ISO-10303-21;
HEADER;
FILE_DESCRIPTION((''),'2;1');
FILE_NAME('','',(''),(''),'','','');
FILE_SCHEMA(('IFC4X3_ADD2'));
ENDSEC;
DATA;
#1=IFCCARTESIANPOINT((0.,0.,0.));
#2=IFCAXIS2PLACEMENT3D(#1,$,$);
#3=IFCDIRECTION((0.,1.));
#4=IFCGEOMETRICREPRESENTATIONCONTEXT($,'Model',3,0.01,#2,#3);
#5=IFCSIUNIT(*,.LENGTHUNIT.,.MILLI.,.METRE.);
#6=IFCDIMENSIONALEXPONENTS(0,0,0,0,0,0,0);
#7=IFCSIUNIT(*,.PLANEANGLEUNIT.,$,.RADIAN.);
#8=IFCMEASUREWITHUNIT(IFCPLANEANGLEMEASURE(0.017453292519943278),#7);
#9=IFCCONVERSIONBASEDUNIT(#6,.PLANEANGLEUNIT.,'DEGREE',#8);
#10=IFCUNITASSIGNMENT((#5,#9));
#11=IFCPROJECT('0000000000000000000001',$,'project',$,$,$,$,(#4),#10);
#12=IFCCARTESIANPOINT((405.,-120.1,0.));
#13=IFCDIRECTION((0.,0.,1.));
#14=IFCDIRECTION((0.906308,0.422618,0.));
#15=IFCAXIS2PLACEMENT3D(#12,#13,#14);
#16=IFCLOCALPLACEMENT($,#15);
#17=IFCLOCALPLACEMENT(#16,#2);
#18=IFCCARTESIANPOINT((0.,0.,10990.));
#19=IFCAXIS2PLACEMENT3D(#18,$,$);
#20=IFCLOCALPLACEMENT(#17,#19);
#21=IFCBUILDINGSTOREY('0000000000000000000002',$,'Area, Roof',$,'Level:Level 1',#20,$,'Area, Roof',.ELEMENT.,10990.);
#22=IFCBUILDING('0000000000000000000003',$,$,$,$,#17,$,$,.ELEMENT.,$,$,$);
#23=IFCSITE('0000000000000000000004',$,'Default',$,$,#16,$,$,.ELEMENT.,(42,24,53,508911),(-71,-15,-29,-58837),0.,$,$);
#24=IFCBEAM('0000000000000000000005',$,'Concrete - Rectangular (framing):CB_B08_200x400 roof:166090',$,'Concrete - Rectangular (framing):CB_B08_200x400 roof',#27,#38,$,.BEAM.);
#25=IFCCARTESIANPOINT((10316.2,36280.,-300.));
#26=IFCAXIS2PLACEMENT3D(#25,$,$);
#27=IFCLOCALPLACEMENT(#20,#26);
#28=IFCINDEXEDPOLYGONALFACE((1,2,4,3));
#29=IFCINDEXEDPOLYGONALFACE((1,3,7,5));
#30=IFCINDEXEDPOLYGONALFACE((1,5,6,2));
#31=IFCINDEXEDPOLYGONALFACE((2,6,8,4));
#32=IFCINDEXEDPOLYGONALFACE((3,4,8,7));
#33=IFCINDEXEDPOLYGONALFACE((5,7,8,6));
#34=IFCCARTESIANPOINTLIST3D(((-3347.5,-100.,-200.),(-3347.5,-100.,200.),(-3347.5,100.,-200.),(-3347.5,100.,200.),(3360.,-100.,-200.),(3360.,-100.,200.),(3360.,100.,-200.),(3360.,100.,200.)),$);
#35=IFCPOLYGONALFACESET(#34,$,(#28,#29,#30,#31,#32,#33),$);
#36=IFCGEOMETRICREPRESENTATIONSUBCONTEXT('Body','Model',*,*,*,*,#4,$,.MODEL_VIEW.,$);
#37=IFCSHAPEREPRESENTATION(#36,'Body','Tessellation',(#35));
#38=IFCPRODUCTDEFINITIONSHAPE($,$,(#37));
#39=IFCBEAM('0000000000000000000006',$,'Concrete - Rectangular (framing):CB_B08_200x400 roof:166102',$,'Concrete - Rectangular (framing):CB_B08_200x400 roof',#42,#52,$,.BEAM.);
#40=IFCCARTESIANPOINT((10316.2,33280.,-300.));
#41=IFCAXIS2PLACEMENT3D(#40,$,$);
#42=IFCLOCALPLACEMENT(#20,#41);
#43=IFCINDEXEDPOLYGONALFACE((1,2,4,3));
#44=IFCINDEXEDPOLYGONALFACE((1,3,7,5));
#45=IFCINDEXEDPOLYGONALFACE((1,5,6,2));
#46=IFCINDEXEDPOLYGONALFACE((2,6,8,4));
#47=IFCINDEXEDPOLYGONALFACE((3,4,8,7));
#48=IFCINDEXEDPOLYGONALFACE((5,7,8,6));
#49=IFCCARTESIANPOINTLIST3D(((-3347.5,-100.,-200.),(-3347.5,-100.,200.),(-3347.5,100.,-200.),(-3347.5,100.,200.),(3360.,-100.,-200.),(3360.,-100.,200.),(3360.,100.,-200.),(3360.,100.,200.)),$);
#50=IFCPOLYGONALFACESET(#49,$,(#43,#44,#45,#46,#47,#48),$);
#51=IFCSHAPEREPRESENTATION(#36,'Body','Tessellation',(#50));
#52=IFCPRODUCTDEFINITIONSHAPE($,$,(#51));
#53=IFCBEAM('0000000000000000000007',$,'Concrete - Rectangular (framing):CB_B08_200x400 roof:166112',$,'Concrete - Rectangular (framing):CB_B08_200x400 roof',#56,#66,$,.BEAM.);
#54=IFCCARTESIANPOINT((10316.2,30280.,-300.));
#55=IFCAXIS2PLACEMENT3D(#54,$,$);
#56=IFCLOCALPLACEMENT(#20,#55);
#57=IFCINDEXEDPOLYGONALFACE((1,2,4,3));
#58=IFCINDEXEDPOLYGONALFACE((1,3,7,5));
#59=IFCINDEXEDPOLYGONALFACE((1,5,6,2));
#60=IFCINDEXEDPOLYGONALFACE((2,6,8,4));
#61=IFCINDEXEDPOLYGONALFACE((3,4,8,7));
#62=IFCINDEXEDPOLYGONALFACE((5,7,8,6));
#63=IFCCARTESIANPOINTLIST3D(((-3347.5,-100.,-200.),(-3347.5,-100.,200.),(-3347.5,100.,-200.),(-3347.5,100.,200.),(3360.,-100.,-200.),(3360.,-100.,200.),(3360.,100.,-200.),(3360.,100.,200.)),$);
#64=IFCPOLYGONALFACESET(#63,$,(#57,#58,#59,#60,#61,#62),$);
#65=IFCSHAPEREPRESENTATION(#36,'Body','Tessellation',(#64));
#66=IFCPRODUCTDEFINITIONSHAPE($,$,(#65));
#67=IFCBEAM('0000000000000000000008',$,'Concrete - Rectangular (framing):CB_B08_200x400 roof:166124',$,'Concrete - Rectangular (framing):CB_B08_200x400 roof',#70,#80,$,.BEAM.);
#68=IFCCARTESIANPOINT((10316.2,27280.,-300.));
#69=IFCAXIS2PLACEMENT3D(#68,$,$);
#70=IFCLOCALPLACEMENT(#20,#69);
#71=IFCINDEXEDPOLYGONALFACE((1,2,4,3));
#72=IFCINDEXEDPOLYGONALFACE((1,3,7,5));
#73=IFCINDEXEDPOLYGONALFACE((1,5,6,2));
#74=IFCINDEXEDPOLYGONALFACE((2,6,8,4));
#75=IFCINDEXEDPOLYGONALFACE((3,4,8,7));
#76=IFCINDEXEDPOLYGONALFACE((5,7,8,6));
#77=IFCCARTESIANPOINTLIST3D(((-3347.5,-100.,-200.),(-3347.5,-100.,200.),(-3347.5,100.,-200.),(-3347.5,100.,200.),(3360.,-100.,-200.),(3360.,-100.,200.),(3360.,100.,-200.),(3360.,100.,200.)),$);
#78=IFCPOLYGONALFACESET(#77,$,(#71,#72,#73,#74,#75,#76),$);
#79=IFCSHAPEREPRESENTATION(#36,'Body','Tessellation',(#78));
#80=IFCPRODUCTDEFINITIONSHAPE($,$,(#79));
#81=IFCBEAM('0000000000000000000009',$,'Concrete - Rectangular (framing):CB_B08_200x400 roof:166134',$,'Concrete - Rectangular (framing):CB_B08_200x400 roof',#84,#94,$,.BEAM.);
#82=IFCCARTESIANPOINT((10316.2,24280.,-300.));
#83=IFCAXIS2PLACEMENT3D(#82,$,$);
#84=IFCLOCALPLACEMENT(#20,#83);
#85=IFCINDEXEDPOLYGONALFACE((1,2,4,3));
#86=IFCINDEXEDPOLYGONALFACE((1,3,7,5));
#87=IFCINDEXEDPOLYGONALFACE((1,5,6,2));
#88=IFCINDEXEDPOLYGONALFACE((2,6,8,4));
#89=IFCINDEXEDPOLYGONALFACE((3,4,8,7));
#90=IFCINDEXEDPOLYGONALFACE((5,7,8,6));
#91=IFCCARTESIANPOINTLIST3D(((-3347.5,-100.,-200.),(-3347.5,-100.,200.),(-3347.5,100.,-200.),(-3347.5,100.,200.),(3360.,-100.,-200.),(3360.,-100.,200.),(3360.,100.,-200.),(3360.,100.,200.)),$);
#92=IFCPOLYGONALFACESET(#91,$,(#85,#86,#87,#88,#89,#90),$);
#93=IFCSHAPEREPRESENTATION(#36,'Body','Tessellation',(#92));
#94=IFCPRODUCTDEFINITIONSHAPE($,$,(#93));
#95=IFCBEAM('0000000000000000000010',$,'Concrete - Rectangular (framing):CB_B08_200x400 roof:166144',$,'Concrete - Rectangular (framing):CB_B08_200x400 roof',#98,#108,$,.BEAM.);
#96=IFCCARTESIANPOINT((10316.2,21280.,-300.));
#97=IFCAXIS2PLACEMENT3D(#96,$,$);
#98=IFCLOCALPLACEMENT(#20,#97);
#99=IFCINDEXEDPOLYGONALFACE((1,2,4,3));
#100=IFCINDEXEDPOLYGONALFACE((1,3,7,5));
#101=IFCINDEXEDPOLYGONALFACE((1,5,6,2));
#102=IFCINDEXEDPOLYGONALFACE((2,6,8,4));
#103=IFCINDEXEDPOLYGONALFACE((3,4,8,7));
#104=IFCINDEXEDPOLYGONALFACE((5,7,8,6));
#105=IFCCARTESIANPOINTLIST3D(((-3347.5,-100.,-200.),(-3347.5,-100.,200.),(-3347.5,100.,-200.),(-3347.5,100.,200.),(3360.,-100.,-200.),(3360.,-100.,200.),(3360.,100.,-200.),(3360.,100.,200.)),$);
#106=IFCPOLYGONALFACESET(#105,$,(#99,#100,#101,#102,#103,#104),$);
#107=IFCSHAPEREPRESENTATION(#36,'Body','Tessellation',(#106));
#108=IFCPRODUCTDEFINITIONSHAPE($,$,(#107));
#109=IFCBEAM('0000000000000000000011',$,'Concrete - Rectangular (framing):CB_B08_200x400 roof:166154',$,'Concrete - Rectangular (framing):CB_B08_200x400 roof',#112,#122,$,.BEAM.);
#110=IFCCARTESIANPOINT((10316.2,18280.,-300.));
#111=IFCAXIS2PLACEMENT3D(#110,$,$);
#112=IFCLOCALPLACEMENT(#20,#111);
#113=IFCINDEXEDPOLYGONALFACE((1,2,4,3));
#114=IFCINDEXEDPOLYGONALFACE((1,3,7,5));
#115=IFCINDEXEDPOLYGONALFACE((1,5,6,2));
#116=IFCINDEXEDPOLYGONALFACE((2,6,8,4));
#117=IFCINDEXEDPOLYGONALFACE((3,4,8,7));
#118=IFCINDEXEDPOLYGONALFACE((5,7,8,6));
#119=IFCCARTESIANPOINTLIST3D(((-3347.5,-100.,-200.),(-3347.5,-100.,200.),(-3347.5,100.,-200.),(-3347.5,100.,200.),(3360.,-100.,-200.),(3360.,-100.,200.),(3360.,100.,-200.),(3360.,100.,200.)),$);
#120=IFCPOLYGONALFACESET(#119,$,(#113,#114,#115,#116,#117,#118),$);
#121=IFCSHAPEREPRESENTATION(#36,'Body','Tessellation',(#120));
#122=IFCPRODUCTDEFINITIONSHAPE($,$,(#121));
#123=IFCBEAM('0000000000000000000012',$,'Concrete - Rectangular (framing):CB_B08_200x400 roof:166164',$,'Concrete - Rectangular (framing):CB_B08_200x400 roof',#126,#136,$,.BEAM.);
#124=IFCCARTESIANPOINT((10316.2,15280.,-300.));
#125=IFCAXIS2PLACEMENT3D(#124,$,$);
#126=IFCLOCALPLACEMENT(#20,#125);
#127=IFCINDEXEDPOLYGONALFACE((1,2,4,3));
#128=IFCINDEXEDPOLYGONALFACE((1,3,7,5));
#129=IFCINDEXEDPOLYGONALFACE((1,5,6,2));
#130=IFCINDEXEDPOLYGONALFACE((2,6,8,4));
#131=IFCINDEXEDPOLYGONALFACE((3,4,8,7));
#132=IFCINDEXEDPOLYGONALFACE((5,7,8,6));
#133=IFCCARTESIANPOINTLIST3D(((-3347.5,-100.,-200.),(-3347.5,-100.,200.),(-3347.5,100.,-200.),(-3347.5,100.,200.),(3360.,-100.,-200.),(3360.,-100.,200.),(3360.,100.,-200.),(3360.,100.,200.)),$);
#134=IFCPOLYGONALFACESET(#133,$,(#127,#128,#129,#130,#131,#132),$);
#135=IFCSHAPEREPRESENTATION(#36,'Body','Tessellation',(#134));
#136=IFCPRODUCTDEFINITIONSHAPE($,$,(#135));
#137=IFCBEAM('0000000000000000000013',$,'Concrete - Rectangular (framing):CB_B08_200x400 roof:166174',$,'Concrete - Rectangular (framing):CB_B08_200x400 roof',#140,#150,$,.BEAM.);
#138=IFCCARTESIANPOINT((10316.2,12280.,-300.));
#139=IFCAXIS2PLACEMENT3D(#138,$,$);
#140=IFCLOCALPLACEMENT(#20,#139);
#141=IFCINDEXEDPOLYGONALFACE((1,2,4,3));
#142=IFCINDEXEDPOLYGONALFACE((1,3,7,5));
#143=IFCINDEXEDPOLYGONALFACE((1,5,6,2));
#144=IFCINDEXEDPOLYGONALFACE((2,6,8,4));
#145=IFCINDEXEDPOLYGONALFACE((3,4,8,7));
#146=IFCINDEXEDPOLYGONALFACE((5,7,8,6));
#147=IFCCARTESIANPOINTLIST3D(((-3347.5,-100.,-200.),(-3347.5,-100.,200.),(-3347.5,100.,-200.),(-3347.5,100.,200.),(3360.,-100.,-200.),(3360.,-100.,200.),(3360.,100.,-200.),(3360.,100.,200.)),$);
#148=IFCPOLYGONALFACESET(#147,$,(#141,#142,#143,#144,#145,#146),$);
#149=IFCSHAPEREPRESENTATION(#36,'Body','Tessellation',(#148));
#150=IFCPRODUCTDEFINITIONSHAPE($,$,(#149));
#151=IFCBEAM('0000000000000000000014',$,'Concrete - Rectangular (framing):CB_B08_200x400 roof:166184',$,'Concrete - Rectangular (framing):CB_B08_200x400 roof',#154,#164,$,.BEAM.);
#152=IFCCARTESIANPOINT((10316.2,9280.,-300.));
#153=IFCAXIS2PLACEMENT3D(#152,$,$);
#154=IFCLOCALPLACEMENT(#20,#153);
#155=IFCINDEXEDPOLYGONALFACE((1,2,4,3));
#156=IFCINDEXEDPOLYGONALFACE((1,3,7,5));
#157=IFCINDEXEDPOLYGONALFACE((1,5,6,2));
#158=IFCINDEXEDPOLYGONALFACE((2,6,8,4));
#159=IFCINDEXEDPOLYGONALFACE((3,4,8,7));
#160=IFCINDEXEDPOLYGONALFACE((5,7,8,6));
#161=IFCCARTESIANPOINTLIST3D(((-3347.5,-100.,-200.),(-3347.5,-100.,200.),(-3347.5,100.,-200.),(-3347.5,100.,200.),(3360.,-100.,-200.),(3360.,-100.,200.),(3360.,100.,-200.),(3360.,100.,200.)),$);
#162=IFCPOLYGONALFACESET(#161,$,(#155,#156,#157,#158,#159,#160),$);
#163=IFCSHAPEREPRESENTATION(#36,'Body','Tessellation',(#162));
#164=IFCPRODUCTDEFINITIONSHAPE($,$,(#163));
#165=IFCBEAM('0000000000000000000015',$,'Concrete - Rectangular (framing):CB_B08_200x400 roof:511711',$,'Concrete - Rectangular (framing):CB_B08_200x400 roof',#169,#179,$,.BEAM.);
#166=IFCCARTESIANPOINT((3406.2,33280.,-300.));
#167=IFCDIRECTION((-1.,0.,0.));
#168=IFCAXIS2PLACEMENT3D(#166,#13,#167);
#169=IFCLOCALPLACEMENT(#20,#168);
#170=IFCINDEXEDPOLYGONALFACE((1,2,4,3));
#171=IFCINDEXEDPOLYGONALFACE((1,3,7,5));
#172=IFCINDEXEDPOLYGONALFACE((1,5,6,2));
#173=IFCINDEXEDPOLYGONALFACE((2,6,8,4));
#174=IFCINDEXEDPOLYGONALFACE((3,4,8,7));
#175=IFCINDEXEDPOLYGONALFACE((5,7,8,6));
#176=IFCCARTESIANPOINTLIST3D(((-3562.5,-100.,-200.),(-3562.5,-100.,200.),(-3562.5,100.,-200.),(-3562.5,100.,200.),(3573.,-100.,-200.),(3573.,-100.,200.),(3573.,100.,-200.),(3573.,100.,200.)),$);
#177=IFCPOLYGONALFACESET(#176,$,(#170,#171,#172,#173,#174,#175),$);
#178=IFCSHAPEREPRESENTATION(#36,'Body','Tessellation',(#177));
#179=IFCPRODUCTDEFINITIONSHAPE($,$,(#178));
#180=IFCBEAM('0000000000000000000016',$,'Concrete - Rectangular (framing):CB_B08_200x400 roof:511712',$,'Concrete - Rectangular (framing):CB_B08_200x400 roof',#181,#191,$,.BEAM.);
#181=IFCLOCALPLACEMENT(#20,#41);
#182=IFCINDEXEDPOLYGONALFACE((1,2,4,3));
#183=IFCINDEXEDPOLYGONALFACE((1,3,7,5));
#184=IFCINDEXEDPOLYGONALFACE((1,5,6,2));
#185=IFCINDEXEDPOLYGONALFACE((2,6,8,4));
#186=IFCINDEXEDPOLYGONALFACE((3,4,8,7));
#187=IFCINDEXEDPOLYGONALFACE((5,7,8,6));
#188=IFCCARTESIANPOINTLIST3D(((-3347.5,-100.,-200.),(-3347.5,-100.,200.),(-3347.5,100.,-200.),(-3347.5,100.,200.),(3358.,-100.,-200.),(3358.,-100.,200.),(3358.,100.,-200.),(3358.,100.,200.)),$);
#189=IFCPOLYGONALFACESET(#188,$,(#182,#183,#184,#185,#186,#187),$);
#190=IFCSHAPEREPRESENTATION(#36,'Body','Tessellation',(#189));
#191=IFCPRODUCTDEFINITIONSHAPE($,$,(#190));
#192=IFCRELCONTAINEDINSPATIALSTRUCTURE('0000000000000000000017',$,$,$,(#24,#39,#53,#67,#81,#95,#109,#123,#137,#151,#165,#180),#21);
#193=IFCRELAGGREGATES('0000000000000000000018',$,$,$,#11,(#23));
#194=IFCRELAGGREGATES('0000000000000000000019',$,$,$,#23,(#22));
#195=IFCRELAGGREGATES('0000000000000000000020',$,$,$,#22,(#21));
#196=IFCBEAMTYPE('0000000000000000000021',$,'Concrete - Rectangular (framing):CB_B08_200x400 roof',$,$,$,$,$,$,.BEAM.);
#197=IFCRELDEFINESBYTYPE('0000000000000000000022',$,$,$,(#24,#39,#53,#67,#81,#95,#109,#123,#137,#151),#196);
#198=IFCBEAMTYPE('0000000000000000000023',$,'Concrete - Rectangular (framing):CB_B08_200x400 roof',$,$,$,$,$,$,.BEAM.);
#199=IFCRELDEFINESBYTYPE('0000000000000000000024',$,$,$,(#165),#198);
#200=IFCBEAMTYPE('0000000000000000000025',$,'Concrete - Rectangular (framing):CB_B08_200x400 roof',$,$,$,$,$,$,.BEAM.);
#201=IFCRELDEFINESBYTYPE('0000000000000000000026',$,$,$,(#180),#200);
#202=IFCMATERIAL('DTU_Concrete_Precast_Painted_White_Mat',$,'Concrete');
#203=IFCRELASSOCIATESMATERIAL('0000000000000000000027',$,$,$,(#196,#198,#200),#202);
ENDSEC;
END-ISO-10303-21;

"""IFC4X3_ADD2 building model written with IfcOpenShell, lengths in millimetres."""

from ifc_helpers import new_model, entity, si_unit, converted_unit, direction, frame, origin, origin_2d_with_axis, place, context, subcontext, project, spatial, rectangle, extrude, source, transform, mapped, material, material_profile, profile_set, type_object, type_shapes, element, save


model = new_model("IFC4X3_ADD2")

# Units and contexts
model_context = context("Model", 3, precision=0.01, world=origin(), true_north=direction((0.0, 1.0)))
body_context = subcontext(model_context, "Body", "Model", "MODEL_VIEW")
ifc_project = project(units=[si_unit("LENGTHUNIT", "METRE", prefix="MILLI"), converted_unit("PLANEANGLEUNIT", "DEGREE", entity("IfcPlaneAngleMeasure", 0.017453292519943278), si_unit("PLANEANGLEUNIT", "RADIAN"), dimensions=[0, 0, 0, 0, 0, 0, 0])], contexts=[model_context])

# Site, building, storey
site_placement = place(None, frame((405.0, -120.1, 0.0), z_axis=(0.0, 0.0, 1.0), x_axis=(0.906308, 0.422618, 0.0)))
site = spatial("IfcSite", under=ifc_project, at=site_placement, Name="Default", CompositionType="ELEMENT", RefLatitude=(42, 24, 53, 508911), RefLongitude=(-71, -15, -29, -58837), RefElevation=0.0)
building_placement = place(site_placement, origin())
building = spatial("IfcBuilding", under=site, at=building_placement, CompositionType="ELEMENT")
storey_placement = place(building_placement, frame((0.0, 0.0, 10990.0)))
storey = spatial("IfcBuildingStorey", under=building, at=storey_placement, Name="Area, Roof", ObjectType="Level:Level 1", LongName="Area, Roof", CompositionType="ELEMENT", Elevation=10990.0)

# Beams
ifc_material = material(Name="DTU_Concrete_Precast_Painted_White_Mat", Category="Concrete")
ifc_material_profile = material_profile(ifc_material, rectangle(XDim=7137.5, YDim=200.0, at=origin_2d_with_axis()), Name="CB_B08_200x400 roof")
ifc_profile_set = profile_set([ifc_material_profile], Name="CB_B08_200x400 roof")
beam_type_1 = type_object("IfcBeamType", Name="Concrete - Rectangular (framing):CB_B08_200x400 roof", PredefinedType="BEAM", material=ifc_profile_set)
shared_shape_1 = source(origin(), body_context, "Body", "SweptSolid", [
    extrude(rectangle(XDim=6707.5, YDim=200.0, at=origin_2d_with_axis()), frame((6.3, 0.0, -200.0), z_axis=(0.0, 0.0, 1.0), x_axis=(-1.0, 0.0, 0.0)), (0.0, 0.0, 1.0), 400.0),
])
type_shapes(beam_type_1, [shared_shape_1])
for number, where, name in (
    (1, (10316.2, 36280.0, -300.0), "Concrete - Rectangular (framing):CB_B08_200x400 roof:166090"),
    (2, (10316.2, 33280.0, -300.0), "Concrete - Rectangular (framing):CB_B08_200x400 roof:166102"),
    (3, (10316.2, 30280.0, -300.0), "Concrete - Rectangular (framing):CB_B08_200x400 roof:166112"),
    (4, (10316.2, 27280.0, -300.0), "Concrete - Rectangular (framing):CB_B08_200x400 roof:166124"),
    (5, (10316.2, 24280.0, -300.0), "Concrete - Rectangular (framing):CB_B08_200x400 roof:166134"),
    (6, (10316.2, 21280.0, -300.0), "Concrete - Rectangular (framing):CB_B08_200x400 roof:166144"),
    (7, (10316.2, 18280.0, -300.0), "Concrete - Rectangular (framing):CB_B08_200x400 roof:166154"),
    (8, (10316.2, 15280.0, -300.0), "Concrete - Rectangular (framing):CB_B08_200x400 roof:166164"),
    (9, (10316.2, 12280.0, -300.0), "Concrete - Rectangular (framing):CB_B08_200x400 roof:166174"),
    (10, (10316.2, 9280.0, -300.0), "Concrete - Rectangular (framing):CB_B08_200x400 roof:166184"),
):
    element("IfcBeam", number, at=place(storey_placement, frame(where)), inside=storey, type_object=beam_type_1, Name=name, ObjectType="Concrete - Rectangular (framing):CB_B08_200x400 roof", PredefinedType="BEAM", context=body_context, shape_type="MappedRepresentation", body=[
        mapped(shared_shape_1, transform((0.0, 0.0, 0.0), scale=1.0)),
    ])
beam_type_2 = type_object("IfcBeamType", Name="Concrete - Rectangular (framing):CB_B08_200x400 roof", PredefinedType="BEAM", material=ifc_profile_set)
shared_shape_2 = source(origin(), body_context, "Body", "SweptSolid", [
    extrude(rectangle(XDim=7135.5, YDim=200.0, at=origin_2d_with_axis()), frame((5.2, 0.0, -200.0), z_axis=(0.0, 0.0, 1.0), x_axis=(-1.0, 0.0, 0.0)), (0.0, 0.0, 1.0), 400.0),
])
type_shapes(beam_type_2, [shared_shape_2])
beam_1_placement = place(storey_placement, frame((3406.2, 33280.0, -300.0), z_axis=(0.0, 0.0, 1.0), x_axis=(-1.0, 0.0, 0.0)))
element("IfcBeam", 11, at=beam_1_placement, inside=storey, type_object=beam_type_2, Name="Concrete - Rectangular (framing):CB_B08_200x400 roof:511711", ObjectType="Concrete - Rectangular (framing):CB_B08_200x400 roof", PredefinedType="BEAM", context=body_context, shape_type="MappedRepresentation", body=[
    mapped(shared_shape_2, transform((0.0, 0.0, 0.0), scale=1.0)),
])
beam_type_3 = type_object("IfcBeamType", Name="Concrete - Rectangular (framing):CB_B08_200x400 roof", PredefinedType="BEAM", material=ifc_profile_set)
shared_shape_3 = source(origin(), body_context, "Body", "SweptSolid", [
    extrude(rectangle(XDim=6705.5, YDim=200.0, at=origin_2d_with_axis()), frame((5.2, 0.0, -200.0), z_axis=(0.0, 0.0, 1.0), x_axis=(-1.0, 0.0, 0.0)), (0.0, 0.0, 1.0), 400.0),
])
type_shapes(beam_type_3, [shared_shape_3])
beam_2_placement = place(storey_placement, frame((10316.2, 33280.0, -300.0)))
element("IfcBeam", 12, at=beam_2_placement, inside=storey, type_object=beam_type_3, Name="Concrete - Rectangular (framing):CB_B08_200x400 roof:511712", ObjectType="Concrete - Rectangular (framing):CB_B08_200x400 roof", PredefinedType="BEAM", context=body_context, shape_type="MappedRepresentation", body=[
    mapped(shared_shape_3, transform((0.0, 0.0, 0.0), scale=1.0)),
])

save(model, "model.ifc")
